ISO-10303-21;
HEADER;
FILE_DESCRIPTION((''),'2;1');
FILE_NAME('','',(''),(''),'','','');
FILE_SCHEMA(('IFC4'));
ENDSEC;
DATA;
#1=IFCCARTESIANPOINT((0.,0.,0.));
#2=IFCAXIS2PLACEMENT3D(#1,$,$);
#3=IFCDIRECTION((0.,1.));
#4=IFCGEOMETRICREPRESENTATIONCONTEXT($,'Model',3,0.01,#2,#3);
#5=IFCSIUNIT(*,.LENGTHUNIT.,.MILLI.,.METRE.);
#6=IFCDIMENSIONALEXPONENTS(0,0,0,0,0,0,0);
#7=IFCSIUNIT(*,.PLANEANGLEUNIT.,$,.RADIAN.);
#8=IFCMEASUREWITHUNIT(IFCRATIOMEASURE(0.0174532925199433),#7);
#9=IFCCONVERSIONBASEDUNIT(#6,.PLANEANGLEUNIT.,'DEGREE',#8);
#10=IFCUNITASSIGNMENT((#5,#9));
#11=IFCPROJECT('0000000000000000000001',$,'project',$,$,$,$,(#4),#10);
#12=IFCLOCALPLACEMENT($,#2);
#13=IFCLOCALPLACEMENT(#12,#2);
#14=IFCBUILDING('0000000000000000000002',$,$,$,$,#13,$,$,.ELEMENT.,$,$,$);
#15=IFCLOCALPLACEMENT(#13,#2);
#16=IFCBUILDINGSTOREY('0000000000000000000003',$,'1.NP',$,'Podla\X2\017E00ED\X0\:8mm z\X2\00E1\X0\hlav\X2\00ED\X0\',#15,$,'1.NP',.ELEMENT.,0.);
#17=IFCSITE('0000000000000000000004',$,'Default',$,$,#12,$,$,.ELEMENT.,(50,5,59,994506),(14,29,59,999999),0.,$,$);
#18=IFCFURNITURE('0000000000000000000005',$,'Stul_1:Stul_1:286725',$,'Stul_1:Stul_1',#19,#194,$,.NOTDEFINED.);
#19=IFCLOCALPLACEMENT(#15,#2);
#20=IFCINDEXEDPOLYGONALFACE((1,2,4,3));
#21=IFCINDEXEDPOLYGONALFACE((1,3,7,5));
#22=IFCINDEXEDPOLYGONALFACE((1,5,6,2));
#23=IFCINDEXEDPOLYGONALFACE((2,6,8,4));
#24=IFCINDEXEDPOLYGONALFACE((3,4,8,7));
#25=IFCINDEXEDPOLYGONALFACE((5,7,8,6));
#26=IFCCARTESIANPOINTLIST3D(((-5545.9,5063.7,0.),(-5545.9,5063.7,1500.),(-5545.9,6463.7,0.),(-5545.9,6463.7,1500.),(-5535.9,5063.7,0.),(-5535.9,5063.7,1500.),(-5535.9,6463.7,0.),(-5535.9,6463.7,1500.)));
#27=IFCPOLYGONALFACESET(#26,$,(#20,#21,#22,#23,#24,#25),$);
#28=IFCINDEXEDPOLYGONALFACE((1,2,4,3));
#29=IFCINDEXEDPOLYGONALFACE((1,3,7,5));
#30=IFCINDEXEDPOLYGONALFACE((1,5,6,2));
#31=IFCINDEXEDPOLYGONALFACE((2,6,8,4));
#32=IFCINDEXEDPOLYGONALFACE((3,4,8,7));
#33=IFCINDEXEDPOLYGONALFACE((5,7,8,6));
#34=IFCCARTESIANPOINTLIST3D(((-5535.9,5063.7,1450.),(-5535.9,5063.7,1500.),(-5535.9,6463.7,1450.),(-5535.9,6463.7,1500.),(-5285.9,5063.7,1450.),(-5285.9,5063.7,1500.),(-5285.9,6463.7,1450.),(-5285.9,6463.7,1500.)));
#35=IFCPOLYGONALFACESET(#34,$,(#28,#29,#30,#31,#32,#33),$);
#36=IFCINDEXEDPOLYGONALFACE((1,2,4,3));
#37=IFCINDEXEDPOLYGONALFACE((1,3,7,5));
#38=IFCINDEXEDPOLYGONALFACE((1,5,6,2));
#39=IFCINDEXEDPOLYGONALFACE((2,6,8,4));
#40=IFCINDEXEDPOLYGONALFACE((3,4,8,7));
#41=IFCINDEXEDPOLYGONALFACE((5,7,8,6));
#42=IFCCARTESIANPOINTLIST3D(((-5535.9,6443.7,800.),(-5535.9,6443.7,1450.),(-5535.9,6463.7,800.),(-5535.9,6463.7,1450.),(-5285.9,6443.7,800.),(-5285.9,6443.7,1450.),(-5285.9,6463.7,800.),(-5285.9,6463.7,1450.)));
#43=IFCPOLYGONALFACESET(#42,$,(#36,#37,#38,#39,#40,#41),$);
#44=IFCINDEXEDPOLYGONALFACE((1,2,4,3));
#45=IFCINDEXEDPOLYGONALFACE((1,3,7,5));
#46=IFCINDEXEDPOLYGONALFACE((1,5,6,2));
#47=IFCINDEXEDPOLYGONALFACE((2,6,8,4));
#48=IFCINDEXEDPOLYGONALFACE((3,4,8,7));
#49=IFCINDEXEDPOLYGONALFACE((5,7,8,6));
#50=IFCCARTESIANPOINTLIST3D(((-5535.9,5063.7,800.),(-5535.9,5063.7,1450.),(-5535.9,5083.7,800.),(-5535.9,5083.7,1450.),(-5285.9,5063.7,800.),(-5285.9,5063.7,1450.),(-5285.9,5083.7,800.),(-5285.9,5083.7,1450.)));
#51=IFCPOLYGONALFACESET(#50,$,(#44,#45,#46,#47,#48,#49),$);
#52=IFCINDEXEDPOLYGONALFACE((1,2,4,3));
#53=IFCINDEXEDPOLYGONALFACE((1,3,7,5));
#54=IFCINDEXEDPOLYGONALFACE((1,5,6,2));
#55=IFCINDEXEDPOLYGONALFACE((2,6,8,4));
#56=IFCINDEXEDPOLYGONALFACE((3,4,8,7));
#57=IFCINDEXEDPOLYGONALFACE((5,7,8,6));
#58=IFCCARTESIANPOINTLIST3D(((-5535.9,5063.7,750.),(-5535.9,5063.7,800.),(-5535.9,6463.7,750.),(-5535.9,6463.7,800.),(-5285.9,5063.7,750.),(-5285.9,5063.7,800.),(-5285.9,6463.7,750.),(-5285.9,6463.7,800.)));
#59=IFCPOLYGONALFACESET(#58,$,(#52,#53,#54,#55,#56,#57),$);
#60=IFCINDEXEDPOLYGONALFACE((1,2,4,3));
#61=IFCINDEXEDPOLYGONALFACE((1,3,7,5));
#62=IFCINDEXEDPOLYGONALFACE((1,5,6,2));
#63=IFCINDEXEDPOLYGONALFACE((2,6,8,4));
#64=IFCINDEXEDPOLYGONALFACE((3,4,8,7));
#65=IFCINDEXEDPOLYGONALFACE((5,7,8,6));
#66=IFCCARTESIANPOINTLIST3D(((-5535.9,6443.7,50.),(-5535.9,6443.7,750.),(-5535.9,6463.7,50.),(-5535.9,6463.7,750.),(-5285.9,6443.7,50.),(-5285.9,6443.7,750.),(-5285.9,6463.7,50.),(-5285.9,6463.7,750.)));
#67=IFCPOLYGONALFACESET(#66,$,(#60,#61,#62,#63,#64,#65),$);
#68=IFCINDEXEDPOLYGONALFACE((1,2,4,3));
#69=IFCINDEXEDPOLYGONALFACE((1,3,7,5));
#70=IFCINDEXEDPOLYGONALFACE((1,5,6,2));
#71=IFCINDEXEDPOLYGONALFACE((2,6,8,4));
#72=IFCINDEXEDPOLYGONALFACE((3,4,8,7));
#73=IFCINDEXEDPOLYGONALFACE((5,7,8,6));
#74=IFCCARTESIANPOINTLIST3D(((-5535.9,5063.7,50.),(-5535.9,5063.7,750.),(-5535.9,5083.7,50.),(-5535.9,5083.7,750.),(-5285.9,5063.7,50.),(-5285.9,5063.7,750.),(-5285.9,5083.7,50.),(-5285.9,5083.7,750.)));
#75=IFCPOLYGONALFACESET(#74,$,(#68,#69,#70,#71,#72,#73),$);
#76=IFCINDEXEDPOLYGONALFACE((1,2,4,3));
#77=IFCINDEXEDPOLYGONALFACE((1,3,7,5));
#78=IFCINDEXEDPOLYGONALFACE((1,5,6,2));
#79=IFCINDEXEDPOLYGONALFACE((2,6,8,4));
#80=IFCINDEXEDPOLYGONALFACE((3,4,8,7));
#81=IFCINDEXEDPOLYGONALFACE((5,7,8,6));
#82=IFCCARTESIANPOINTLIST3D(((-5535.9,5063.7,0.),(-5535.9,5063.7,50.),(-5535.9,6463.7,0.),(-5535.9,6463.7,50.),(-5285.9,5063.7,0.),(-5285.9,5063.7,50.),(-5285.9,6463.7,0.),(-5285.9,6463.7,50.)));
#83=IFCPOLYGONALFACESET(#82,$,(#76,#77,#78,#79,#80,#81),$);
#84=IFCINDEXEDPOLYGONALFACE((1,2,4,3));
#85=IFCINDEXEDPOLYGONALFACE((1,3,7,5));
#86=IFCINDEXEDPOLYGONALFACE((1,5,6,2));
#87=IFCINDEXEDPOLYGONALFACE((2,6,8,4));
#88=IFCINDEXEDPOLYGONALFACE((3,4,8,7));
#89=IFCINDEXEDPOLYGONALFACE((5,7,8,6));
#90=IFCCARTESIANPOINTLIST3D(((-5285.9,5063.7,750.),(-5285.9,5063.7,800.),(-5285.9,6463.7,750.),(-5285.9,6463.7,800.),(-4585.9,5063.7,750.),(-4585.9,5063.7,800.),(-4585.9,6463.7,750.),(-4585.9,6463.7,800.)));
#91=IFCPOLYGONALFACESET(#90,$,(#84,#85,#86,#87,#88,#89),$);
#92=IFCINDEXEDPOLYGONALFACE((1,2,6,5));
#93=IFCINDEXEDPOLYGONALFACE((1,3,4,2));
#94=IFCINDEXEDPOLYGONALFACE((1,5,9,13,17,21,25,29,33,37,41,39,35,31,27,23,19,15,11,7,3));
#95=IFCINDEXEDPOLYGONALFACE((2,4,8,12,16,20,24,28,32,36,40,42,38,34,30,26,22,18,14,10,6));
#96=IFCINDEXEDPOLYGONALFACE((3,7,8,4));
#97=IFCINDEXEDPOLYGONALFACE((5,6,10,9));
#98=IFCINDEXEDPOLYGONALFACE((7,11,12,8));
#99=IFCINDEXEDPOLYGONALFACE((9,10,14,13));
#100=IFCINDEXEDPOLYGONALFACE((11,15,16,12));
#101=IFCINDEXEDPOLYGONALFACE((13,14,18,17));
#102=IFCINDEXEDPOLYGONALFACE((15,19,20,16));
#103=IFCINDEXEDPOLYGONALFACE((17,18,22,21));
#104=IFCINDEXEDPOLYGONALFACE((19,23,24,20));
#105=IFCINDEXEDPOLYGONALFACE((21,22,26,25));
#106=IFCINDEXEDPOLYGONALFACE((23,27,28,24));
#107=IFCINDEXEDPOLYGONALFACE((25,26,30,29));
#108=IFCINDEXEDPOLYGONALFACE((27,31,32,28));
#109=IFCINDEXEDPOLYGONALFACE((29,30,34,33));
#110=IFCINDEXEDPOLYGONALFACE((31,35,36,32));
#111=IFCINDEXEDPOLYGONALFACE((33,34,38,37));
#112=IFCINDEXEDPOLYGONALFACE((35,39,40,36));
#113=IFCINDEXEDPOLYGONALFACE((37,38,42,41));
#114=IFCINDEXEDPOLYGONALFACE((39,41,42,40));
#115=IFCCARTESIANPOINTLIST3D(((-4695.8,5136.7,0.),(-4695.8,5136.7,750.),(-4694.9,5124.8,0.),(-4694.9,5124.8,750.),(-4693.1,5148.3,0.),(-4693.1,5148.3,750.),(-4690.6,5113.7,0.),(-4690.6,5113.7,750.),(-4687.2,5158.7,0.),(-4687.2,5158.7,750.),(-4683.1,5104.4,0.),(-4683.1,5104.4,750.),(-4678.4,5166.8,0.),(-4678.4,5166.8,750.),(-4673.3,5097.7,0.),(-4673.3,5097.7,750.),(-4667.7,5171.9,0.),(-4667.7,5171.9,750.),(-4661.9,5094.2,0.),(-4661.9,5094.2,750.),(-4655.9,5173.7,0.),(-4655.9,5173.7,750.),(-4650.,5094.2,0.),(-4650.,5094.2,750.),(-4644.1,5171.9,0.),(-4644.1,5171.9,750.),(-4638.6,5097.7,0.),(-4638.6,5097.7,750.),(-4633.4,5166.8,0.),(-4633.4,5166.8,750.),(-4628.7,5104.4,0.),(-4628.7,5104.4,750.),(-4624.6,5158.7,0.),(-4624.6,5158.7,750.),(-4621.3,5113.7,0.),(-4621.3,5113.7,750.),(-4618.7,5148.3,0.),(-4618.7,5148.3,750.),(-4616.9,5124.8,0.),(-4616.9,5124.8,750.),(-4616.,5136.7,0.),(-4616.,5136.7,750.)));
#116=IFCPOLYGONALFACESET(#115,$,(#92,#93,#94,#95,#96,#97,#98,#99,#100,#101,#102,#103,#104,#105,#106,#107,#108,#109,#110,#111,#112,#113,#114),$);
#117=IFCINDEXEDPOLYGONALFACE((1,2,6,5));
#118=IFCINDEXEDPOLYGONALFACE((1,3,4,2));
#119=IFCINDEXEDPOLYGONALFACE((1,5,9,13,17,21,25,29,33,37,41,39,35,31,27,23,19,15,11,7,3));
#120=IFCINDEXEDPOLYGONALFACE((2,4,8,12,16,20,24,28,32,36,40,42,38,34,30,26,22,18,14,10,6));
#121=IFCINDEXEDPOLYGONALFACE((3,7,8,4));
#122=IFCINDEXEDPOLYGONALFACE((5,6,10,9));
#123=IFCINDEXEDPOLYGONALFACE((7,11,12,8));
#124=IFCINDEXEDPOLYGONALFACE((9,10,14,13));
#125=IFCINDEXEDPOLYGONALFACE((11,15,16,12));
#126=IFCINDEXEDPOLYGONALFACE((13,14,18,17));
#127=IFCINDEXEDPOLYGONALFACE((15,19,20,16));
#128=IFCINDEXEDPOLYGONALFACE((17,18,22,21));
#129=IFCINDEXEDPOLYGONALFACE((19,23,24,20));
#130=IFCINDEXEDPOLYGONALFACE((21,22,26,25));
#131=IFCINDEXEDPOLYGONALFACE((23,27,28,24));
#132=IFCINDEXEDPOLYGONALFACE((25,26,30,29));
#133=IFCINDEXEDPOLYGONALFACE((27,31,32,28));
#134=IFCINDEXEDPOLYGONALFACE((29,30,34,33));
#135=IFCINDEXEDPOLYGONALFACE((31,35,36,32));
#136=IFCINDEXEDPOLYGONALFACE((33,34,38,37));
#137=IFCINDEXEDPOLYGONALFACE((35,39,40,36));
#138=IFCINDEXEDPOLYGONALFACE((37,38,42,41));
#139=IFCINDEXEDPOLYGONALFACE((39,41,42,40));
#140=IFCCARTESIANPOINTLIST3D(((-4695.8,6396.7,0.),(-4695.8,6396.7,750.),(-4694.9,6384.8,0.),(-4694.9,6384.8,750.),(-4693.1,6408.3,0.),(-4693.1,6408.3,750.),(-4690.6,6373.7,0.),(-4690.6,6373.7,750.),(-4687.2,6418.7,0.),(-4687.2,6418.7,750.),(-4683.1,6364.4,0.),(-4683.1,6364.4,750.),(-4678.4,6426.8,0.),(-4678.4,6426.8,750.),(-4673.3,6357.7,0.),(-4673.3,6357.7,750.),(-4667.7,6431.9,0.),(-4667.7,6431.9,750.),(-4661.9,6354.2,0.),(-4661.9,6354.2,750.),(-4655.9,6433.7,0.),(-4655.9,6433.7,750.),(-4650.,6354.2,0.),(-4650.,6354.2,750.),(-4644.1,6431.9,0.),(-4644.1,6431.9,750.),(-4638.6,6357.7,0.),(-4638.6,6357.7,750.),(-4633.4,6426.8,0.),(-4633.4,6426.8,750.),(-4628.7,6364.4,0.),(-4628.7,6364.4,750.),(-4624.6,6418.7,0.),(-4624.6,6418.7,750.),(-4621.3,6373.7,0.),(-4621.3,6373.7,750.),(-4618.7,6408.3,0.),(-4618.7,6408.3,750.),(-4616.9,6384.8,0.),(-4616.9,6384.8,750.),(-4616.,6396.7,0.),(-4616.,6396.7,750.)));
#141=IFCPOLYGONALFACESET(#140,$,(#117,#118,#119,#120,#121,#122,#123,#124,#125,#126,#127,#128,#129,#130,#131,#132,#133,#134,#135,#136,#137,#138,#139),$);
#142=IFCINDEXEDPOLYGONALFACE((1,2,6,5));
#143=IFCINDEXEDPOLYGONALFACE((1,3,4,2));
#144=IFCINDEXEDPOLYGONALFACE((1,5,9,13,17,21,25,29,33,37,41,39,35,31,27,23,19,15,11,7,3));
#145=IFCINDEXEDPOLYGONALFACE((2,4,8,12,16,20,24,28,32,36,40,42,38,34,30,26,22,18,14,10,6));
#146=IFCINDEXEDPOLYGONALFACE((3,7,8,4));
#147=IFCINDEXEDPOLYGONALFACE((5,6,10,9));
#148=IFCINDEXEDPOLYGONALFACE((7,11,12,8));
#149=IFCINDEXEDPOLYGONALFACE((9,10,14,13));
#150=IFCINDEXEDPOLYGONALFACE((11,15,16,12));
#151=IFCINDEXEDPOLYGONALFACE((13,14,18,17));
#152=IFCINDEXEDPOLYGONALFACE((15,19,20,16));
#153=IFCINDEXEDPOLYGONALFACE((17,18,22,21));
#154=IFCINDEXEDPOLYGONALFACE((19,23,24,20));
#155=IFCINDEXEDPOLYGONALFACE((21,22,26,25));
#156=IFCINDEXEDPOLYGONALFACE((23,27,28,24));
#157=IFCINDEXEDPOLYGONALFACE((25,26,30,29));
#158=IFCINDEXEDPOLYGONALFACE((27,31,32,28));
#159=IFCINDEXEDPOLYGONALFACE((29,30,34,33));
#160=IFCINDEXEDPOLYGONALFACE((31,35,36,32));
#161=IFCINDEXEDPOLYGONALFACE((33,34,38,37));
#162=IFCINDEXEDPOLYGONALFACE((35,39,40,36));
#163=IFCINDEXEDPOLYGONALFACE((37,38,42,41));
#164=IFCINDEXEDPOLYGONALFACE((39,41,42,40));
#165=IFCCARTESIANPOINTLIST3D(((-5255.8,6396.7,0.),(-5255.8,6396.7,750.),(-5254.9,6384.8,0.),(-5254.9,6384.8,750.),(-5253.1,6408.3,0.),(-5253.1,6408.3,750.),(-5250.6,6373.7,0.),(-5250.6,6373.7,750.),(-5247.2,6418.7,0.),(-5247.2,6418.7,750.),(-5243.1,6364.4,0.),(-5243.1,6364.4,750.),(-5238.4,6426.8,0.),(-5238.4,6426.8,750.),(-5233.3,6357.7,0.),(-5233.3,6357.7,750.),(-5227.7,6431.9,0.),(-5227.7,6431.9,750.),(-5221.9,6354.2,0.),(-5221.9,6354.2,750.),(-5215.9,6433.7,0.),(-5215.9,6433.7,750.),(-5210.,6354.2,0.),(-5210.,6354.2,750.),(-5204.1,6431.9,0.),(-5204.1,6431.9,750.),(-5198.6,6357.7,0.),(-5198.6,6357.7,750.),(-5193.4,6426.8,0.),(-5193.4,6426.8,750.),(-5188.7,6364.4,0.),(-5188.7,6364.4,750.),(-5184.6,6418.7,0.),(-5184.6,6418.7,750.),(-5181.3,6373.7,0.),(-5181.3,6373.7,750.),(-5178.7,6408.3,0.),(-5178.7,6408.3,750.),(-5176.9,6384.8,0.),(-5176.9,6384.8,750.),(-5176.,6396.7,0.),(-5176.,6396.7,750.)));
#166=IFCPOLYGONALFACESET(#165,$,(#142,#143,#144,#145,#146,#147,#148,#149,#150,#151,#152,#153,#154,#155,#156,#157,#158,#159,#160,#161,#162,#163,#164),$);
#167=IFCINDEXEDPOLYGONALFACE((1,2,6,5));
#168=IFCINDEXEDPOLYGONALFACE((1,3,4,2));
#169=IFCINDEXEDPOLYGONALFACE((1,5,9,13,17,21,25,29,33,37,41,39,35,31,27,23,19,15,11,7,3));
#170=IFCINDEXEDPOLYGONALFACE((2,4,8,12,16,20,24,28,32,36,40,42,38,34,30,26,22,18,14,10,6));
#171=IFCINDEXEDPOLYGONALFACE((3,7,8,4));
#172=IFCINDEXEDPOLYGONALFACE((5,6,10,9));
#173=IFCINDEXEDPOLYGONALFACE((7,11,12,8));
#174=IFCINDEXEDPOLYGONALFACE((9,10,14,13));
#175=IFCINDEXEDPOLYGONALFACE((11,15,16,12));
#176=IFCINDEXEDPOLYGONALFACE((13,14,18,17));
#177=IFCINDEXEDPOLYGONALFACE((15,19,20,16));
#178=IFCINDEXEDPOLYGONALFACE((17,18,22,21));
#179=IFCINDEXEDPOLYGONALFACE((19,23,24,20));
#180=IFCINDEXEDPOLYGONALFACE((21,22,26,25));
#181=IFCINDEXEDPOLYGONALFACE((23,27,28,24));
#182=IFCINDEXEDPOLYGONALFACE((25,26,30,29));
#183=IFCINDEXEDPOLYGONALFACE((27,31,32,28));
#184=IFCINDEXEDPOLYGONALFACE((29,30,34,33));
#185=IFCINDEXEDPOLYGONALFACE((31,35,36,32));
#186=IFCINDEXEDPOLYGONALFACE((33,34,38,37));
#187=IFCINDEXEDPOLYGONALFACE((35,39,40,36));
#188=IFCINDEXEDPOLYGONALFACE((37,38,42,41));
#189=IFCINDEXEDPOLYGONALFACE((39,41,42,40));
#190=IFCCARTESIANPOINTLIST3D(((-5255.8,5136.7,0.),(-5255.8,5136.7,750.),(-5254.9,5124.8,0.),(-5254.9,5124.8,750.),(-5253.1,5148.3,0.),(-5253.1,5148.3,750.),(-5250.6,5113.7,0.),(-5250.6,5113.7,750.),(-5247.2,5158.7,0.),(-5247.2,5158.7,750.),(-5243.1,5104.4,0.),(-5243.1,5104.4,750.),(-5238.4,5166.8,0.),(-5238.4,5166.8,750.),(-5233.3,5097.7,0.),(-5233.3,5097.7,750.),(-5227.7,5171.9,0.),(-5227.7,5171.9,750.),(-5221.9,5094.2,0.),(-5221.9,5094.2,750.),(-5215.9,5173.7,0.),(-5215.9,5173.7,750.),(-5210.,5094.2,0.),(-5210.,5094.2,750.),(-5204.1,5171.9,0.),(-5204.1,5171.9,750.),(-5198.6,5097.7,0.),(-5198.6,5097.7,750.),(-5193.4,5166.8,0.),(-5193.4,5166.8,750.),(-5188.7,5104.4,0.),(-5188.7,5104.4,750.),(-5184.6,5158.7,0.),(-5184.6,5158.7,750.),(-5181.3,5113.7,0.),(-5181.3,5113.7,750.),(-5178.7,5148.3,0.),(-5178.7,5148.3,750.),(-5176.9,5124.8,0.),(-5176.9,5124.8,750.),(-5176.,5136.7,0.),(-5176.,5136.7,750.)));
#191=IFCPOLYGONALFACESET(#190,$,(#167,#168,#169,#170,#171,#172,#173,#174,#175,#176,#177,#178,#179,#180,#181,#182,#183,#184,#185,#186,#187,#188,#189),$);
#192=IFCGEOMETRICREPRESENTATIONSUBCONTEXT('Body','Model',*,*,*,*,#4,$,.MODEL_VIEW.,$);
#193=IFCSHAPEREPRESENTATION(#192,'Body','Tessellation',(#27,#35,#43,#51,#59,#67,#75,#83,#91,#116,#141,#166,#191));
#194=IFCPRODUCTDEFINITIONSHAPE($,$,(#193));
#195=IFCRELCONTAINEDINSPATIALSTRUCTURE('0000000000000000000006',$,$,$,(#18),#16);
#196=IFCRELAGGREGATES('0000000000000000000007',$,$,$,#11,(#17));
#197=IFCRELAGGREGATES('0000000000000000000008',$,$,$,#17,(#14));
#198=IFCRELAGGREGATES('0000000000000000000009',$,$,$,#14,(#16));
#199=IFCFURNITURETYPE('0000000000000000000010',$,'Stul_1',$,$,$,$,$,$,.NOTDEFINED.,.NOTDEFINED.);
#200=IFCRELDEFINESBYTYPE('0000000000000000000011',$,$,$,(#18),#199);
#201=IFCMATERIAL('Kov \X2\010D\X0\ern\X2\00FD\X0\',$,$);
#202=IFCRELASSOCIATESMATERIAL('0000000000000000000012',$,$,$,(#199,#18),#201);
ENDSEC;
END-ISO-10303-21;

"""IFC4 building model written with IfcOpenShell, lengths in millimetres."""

from ifc_helpers import new_model, entity, si_unit, converted_unit, direction, frame, frame_2d, origin, origin_2d_with_axis, place, context, subcontext, project, spatial, rectangle, circle, extrude, source, transform, mapped, material, type_object, type_shapes, element, save


model = new_model("IFC4")

# Units and contexts
model_context = context("Model", 3, precision=0.01, world=origin(), true_north=direction((0.0, 1.0)))
body_context = subcontext(model_context, "Body", "Model", "MODEL_VIEW")
ifc_project = project(units=[si_unit("LENGTHUNIT", "METRE", prefix="MILLI"), converted_unit("PLANEANGLEUNIT", "DEGREE", entity("IfcRatioMeasure", 0.0174532925199433), si_unit("PLANEANGLEUNIT", "RADIAN"), dimensions=[0, 0, 0, 0, 0, 0, 0])], contexts=[model_context])

# Site, building, storey
site_placement = place(None, origin())
site = spatial("IfcSite", under=ifc_project, at=site_placement, Name="Default", CompositionType="ELEMENT", RefLatitude=(50, 5, 59, 994506), RefLongitude=(14, 29, 59, 999999), RefElevation=0.0)
building_placement = place(site_placement, origin())
building = spatial("IfcBuilding", under=site, at=building_placement, CompositionType="ELEMENT")
storey_placement = place(building_placement, origin())
storey = spatial("IfcBuildingStorey", under=building, at=storey_placement, Name="1.NP", ObjectType="Podlaží:8mm záhlaví", LongName="1.NP", CompositionType="ELEMENT", Elevation=0.0)

# Furniture
ifc_material_1 = material(Name="Kov černý")
furniture_type = type_object("IfcFurnitureType", Name="Stul_1", AssemblyPlace="NOTDEFINED", PredefinedType="NOTDEFINED", material=ifc_material_1)
shared_shape_1 = source(origin(), body_context, "Body", "SweptSolid", [
    extrude(rectangle(XDim=1400.0, YDim=10.0, at=origin_2d_with_axis()), frame((0.0, 605.0, 0.0), z_axis=(0.0, 0.0, 1.0), x_axis=(-1.0, 0.0, 0.0)), (0.0, 0.0, 1.0), 1500.0),
    extrude(rectangle(XDim=1400.0, YDim=250.0, at=frame_2d((0.0, 0.0), x_axis=(1.0, 0.0))), frame((0.0, 475.0, 1450.0), z_axis=(0.0, 0.0, 1.0), x_axis=(-1.0, 0.0, 0.0)), (0.0, 0.0, 1.0), 50.0),
    extrude(rectangle(XDim=20.0, YDim=250.0, at=origin_2d_with_axis()), frame((690.0, 475.0, 800.0), z_axis=(0.0, 0.0, 1.0), x_axis=(-1.0, 0.0, 0.0)), (0.0, 0.0, 1.0), 650.0),
    extrude(rectangle(XDim=20.0, YDim=250.0, at=frame_2d((0.0, 0.0), x_axis=(1.0, 0.0))), frame((-690.0, 475.0, 800.0), z_axis=(0.0, 0.0, 1.0), x_axis=(-1.0, 0.0, 0.0)), (0.0, 0.0, 1.0), 650.0),
    extrude(rectangle(XDim=1400.0, YDim=250.0, at=origin_2d_with_axis()), frame((0.0, 475.0, 750.0), z_axis=(0.0, 0.0, 1.0), x_axis=(-1.0, 0.0, 0.0)), (0.0, 0.0, 1.0), 50.0),
    extrude(rectangle(XDim=20.0, YDim=250.0, at=origin_2d_with_axis()), frame((690.0, 475.0, 50.0), z_axis=(0.0, 0.0, 1.0), x_axis=(-1.0, 0.0, 0.0)), (0.0, 0.0, 1.0), 700.0),
    extrude(rectangle(XDim=20.0, YDim=250.0, at=frame_2d((0.0, 0.0), x_axis=(1.0, 0.0))), frame((-690.0, 475.0, 50.0), z_axis=(0.0, 0.0, 1.0), x_axis=(-1.0, 0.0, 0.0)), (0.0, 0.0, 1.0), 700.0),
    extrude(rectangle(XDim=1400.0, YDim=250.0, at=origin_2d_with_axis()), frame((0.0, 475.0, 0.0), z_axis=(0.0, 0.0, 1.0), x_axis=(-1.0, 0.0, 0.0)), (0.0, 0.0, 1.0), 50.0),
    extrude(rectangle(XDim=1400.0, YDim=700.0, at=origin_2d_with_axis()), frame((0.0, 0.0, 750.0), z_axis=(0.0, 0.0, 1.0), x_axis=(-1.0, 0.0, 0.0)), (0.0, 0.0, 1.0), 50.0),
    extrude(circle(Radius=40.0, at=frame_2d((0.0, 0.0), x_axis=(1.0, 0.0))), frame((-630.0, -280.0, 0.0)), (0.0, 0.0, 1.0), 750.0),
    extrude(circle(Radius=40.0, at=frame_2d((0.0, 0.0), x_axis=(1.0, 0.0))), frame((630.0, -280.0, 0.0)), (0.0, 0.0, 1.0), 750.0),
    extrude(circle(Radius=40.0, at=frame_2d((0.0, 0.0), x_axis=(1.0, 0.0))), frame((630.0, 280.0, 0.0)), (0.0, 0.0, 1.0), 750.0),
    extrude(circle(Radius=40.0, at=frame_2d((0.0, 0.0), x_axis=(1.0, 0.0))), frame((-630.0, 280.0, 0.0)), (0.0, 0.0, 1.0), 750.0),
])
type_shapes(furniture_type, [shared_shape_1])
for number, where, z_axis, x_axis, name in (
    (1, (-4935.9, 5763.7, 0.0), (0.0, 0.0, 1.0), (0.0, 1.0, 0.0), "Stul_1:Stul_1:286725"),
):
    element("IfcFurniture", number, at=place(storey_placement, frame(where, z_axis=z_axis, x_axis=x_axis)), inside=storey, type_object=furniture_type, material=ifc_material_1, Name=name, ObjectType="Stul_1:Stul_1", PredefinedType="NOTDEFINED", context=body_context, shape_type="MappedRepresentation", body=[
        mapped(shared_shape_1, transform((0.0, 0.0, 0.0), scale=1.0)),
    ])

save(model, "model.ifc")
